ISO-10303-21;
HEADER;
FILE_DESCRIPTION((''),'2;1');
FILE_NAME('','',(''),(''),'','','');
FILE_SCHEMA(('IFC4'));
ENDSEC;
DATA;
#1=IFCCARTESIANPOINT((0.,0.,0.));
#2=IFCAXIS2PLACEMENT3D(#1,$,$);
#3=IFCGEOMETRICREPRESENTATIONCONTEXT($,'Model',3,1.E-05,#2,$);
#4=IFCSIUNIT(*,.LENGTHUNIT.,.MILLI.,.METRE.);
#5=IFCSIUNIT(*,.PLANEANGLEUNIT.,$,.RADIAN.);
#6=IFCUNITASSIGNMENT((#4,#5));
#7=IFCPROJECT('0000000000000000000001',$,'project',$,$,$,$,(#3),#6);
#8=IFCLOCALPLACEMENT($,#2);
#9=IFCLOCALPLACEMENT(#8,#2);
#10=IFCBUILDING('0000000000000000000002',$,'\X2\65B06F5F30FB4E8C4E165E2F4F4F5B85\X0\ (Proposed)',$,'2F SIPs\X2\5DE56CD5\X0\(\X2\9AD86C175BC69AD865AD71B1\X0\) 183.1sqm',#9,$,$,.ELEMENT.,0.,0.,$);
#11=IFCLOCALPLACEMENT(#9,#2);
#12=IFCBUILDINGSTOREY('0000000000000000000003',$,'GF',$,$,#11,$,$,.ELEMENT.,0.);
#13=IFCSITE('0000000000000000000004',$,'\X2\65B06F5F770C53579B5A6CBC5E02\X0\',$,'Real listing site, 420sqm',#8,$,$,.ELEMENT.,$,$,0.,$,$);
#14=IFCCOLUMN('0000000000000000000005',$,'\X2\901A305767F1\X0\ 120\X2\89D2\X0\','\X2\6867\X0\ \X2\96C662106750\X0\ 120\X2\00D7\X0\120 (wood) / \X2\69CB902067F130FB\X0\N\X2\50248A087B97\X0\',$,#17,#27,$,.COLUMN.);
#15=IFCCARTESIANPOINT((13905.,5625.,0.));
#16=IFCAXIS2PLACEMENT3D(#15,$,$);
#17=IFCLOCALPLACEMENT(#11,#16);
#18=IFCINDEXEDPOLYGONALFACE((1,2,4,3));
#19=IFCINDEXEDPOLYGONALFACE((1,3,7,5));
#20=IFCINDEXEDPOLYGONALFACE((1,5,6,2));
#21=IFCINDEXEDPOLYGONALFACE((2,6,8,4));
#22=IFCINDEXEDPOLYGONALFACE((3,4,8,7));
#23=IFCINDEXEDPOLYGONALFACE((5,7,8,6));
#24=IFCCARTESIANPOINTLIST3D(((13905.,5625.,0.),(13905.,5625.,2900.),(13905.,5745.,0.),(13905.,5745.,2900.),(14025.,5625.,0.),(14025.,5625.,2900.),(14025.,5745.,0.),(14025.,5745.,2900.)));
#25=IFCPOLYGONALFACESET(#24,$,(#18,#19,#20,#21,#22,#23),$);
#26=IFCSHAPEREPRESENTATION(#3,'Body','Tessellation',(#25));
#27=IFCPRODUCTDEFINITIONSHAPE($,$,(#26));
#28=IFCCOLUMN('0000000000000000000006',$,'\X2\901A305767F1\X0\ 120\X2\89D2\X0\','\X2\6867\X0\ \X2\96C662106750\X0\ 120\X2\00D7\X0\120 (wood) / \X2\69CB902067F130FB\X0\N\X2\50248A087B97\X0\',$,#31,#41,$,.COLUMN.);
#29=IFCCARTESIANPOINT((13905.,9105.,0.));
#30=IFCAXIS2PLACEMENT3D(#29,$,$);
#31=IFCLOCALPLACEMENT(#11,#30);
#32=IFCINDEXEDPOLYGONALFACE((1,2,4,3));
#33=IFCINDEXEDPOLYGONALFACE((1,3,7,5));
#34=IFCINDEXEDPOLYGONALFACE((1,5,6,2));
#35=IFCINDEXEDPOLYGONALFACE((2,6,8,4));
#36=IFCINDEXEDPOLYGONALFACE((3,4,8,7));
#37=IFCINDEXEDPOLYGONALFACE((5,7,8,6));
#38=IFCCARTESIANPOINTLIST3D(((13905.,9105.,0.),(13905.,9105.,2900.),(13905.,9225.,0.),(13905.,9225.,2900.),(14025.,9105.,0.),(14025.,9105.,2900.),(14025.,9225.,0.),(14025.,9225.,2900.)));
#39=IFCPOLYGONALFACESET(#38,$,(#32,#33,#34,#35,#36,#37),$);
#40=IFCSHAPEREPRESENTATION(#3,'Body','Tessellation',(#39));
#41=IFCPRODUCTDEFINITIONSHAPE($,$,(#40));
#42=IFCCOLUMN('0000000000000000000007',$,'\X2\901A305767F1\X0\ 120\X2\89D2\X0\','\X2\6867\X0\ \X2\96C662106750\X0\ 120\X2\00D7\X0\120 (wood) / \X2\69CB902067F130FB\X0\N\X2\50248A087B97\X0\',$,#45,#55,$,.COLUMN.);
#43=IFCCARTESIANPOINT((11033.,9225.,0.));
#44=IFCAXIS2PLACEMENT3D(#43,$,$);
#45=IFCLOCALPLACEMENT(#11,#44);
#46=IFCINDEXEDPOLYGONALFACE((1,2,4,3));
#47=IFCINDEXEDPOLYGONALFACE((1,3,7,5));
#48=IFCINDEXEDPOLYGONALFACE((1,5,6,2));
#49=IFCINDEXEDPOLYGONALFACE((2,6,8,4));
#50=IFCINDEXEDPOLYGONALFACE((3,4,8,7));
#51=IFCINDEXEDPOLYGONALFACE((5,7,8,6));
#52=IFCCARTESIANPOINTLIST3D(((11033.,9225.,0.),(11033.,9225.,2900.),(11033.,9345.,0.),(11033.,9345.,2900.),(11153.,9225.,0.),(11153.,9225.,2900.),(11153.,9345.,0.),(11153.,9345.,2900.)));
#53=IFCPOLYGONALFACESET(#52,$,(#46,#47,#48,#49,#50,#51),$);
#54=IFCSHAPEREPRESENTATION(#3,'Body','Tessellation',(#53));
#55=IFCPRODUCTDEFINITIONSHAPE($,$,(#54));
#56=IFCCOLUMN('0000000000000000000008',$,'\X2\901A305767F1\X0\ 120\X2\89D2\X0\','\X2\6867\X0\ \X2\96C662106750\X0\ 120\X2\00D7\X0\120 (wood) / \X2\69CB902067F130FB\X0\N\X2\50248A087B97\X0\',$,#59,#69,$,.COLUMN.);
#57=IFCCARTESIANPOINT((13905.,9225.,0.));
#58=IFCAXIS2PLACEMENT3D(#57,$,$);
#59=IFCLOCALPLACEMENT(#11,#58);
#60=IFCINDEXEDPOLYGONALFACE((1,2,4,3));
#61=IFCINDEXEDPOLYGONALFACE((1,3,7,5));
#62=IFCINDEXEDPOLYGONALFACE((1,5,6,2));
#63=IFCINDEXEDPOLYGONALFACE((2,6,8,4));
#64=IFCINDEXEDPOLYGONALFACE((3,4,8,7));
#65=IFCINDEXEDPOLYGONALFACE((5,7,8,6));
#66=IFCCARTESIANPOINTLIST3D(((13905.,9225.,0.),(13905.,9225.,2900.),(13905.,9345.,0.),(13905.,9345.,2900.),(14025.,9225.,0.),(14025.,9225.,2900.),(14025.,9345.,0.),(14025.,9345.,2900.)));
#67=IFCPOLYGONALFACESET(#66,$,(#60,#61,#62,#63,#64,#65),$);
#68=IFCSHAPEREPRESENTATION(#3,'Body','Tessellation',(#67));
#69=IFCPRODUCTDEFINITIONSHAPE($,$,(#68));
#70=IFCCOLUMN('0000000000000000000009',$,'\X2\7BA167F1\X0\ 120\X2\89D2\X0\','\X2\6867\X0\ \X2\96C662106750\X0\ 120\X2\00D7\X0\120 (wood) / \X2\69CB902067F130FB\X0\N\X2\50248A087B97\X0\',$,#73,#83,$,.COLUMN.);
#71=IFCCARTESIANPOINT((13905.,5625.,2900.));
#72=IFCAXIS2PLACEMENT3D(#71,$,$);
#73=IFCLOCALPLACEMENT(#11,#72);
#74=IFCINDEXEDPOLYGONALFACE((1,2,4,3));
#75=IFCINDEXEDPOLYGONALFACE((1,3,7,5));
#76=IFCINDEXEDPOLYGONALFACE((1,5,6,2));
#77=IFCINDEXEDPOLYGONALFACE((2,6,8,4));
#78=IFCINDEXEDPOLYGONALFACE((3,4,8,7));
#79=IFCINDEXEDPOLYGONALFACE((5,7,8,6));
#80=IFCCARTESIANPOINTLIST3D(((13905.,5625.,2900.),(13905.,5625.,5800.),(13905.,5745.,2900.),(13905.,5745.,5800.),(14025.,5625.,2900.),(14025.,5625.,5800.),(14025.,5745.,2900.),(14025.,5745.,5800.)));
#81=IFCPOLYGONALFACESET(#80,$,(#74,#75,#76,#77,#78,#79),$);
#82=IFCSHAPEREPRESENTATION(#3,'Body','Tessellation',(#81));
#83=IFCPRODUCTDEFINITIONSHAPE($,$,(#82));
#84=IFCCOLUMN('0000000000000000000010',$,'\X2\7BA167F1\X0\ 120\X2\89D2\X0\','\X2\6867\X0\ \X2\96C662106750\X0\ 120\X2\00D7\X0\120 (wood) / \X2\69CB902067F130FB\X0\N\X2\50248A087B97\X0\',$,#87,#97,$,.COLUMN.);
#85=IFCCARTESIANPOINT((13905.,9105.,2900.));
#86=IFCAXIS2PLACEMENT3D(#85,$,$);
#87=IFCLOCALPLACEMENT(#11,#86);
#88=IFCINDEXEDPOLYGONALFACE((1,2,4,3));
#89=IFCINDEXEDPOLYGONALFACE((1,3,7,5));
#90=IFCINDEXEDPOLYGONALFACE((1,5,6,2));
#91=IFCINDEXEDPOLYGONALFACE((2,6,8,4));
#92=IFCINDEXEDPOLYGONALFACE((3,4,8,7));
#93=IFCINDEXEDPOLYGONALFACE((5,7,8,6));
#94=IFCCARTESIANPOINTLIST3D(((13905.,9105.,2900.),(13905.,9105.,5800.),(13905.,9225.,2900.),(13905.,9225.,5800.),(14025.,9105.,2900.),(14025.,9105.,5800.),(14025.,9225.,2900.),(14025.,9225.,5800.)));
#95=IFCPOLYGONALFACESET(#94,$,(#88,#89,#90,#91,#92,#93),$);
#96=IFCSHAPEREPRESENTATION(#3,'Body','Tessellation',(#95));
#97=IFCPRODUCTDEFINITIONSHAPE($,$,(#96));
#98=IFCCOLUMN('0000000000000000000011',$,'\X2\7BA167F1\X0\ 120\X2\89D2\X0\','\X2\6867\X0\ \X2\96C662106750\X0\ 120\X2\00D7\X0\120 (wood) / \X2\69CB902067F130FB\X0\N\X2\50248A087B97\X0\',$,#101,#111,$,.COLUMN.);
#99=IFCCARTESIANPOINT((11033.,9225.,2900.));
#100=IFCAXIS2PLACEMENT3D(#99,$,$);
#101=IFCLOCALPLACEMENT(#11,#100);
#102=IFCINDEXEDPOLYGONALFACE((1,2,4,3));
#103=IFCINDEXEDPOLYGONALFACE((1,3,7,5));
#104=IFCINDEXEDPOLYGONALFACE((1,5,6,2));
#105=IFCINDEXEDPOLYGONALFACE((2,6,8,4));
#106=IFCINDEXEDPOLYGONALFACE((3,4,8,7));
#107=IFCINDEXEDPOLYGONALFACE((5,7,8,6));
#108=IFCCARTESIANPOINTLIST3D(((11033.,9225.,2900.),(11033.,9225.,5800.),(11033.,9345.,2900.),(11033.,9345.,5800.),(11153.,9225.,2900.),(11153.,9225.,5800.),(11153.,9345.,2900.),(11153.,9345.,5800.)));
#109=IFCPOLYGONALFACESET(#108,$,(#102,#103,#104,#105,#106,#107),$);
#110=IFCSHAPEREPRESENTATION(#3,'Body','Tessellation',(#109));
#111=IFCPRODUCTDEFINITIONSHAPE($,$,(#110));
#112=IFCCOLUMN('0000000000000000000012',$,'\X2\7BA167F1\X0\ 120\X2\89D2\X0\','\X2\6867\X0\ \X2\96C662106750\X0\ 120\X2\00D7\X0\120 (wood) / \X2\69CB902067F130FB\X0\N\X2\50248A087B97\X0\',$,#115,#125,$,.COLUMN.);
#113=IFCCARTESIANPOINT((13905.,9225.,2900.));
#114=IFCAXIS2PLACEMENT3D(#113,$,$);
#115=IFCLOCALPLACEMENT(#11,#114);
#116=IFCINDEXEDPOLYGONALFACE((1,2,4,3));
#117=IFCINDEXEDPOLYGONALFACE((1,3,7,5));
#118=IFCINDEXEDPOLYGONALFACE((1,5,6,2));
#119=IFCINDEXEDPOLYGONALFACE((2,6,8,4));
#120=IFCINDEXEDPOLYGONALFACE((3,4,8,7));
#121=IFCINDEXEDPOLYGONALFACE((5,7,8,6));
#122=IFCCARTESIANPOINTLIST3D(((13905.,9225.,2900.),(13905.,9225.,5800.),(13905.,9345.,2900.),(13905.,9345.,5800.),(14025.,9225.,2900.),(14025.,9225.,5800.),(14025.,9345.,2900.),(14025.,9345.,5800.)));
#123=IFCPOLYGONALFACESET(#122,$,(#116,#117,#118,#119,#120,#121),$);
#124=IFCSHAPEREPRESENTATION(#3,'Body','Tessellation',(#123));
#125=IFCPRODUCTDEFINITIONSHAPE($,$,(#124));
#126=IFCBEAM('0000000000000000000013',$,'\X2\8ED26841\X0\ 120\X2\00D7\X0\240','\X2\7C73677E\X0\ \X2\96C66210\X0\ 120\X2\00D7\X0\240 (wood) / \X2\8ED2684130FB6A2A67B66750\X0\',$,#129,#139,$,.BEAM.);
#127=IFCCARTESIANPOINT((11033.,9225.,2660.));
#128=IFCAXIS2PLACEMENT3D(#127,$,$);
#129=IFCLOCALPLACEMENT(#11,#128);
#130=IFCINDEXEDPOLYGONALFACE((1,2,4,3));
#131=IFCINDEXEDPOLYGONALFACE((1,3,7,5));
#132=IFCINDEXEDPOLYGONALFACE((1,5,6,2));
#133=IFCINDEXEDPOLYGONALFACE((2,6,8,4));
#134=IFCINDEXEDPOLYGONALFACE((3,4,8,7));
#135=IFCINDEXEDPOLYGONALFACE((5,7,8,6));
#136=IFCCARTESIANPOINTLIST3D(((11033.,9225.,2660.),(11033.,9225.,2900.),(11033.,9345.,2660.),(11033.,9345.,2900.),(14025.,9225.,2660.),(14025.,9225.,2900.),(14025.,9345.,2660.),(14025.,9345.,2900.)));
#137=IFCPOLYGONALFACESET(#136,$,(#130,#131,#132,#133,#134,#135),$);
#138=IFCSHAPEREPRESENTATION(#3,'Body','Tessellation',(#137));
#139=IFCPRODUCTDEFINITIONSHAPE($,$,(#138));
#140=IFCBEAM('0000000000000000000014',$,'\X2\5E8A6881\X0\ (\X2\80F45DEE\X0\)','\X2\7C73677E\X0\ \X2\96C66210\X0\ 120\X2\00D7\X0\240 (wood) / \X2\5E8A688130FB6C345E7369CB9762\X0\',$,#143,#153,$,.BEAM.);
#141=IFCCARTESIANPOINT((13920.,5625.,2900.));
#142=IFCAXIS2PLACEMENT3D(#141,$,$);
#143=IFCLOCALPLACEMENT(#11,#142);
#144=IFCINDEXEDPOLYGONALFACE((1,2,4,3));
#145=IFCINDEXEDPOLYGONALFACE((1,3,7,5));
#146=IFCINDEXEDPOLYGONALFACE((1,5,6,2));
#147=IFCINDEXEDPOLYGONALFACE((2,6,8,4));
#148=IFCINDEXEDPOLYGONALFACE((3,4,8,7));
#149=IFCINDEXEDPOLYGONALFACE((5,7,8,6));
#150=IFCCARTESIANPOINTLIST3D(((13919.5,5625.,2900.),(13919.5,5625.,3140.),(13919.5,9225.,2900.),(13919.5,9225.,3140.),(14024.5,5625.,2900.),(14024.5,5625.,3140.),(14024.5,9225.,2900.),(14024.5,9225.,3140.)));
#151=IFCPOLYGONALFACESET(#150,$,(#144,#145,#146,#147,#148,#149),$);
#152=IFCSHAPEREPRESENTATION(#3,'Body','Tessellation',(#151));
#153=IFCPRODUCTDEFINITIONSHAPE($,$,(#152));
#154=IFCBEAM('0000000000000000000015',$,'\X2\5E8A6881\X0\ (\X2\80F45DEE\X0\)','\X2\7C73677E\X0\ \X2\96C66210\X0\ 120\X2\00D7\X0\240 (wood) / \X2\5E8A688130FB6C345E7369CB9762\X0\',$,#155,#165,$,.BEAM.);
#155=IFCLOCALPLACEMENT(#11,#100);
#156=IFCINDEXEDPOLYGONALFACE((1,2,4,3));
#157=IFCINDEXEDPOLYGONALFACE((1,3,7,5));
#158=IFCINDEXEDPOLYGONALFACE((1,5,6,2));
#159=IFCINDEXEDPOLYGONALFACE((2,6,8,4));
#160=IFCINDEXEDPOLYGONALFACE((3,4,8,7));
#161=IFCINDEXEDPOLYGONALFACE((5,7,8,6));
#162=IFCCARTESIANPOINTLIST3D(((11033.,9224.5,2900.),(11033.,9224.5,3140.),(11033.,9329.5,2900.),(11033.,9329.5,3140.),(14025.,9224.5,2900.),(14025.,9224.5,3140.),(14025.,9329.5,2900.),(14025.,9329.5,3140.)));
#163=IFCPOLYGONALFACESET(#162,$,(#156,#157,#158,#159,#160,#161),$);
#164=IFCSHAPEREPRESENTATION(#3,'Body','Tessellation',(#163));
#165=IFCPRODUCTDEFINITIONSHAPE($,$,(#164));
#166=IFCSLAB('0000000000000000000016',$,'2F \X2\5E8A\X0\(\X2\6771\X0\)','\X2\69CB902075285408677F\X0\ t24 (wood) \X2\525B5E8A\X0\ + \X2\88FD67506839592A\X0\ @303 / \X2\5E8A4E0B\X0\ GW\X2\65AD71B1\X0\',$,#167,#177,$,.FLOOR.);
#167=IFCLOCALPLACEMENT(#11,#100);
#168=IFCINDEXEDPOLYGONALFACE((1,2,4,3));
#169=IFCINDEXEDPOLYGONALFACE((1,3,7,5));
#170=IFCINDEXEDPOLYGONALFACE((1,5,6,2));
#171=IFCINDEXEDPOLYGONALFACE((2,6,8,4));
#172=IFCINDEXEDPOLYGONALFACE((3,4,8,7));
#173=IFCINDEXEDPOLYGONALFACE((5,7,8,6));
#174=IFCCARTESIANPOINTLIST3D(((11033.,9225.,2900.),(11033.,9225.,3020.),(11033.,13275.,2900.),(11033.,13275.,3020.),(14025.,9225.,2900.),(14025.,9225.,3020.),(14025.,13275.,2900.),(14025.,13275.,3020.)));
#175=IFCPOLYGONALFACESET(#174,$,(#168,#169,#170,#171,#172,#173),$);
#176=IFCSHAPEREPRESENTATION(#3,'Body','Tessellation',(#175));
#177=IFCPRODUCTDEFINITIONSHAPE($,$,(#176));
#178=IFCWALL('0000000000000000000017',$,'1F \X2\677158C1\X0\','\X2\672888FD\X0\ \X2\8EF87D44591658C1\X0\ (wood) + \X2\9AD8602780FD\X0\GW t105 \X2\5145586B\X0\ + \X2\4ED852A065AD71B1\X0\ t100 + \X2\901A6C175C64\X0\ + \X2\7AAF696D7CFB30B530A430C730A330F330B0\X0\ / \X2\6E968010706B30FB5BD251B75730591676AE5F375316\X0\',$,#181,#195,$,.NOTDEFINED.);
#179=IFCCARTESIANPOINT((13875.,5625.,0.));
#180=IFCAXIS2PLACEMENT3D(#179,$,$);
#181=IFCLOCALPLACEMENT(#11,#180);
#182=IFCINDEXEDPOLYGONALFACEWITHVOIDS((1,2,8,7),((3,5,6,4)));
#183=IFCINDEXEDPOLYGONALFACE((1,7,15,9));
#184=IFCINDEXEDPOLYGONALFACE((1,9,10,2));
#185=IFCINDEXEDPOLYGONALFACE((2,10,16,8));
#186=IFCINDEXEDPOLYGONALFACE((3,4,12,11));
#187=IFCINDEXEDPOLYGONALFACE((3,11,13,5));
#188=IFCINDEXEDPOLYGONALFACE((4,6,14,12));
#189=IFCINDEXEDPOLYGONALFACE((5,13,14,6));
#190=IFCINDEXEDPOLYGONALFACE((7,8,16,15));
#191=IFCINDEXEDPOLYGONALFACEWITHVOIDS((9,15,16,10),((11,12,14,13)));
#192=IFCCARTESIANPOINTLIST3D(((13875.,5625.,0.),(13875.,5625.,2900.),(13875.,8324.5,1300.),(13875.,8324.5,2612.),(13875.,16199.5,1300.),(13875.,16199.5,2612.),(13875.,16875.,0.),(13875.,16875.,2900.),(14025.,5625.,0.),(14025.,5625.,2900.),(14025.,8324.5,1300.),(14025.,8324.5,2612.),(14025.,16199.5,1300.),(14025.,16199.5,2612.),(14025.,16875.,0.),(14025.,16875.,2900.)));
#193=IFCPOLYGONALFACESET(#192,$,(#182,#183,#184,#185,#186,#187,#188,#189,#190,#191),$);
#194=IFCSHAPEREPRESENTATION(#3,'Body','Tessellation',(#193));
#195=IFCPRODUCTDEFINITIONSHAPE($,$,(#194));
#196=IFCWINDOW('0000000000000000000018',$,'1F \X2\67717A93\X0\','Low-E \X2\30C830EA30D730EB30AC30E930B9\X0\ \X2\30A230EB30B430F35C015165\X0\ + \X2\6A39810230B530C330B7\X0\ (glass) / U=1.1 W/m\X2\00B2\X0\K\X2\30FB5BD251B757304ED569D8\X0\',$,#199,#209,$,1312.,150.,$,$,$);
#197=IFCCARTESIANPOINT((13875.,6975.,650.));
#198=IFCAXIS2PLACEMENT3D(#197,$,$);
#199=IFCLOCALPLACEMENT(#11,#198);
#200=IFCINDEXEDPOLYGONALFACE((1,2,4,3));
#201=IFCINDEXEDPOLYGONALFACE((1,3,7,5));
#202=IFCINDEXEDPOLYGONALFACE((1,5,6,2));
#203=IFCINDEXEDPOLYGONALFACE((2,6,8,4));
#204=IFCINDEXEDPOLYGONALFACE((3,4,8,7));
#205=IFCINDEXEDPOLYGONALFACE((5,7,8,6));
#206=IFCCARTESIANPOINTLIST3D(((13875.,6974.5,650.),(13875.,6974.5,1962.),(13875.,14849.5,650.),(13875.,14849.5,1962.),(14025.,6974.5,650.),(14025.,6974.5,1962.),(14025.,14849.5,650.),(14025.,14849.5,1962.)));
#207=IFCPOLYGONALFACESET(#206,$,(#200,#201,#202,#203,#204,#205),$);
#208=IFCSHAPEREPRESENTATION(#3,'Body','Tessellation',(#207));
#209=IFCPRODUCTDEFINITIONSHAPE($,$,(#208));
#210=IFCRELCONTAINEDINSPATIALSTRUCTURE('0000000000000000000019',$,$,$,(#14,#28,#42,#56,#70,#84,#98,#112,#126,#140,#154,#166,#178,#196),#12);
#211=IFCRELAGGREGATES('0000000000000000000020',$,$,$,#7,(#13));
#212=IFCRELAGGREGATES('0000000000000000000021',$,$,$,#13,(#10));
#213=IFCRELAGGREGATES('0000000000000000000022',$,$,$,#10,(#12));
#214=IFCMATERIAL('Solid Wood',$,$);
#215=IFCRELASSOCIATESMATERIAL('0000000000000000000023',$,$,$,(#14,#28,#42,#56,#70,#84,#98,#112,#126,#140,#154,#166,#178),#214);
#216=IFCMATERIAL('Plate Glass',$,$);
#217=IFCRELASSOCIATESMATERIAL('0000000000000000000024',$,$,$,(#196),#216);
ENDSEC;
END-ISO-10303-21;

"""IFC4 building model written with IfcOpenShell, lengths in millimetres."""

from ifc_helpers import new_model, si_unit, frame, frame_2d, origin, place, context, project, spatial, rectangle, extrude, material, element, fill, save


model = new_model("IFC4")

# Units and contexts
model_context = context("Model", 3, precision=1e-05, world=origin())
ifc_project = project(units=[si_unit("LENGTHUNIT", "METRE", prefix="MILLI"), si_unit("PLANEANGLEUNIT", "RADIAN")], contexts=[model_context])

# Site, building, storey
site_placement = place(None, origin())
site = spatial("IfcSite", under=ifc_project, at=site_placement, Name="新潟県南魚沼市", ObjectType="Real listing site, 420sqm", CompositionType="ELEMENT", RefElevation=0.0)
building_placement = place(site_placement, origin())
building = spatial("IfcBuilding", under=site, at=building_placement, Name="新潟・二世帯住宅 (Proposed)", ObjectType="2F SIPs工法(高気密高断熱) 183.1sqm", CompositionType="ELEMENT", ElevationOfRefHeight=0.0, ElevationOfTerrain=0.0)
storey_placement = place(building_placement, origin())
storey = spatial("IfcBuildingStorey", under=building, at=storey_placement, Name="GF", CompositionType="ELEMENT", Elevation=0.0)

# Columns
ifc_material_1 = material(Name="Solid Wood")
column_1_placement = place(storey_placement, frame((13905.0, 5625.0, 0.0)))
element("IfcColumn", 1, at=column_1_placement, inside=storey, material=ifc_material_1, Name="通し柱 120角", Description="桧 集成材 120×120 (wood) / 構造柱・N値計算", PredefinedType="COLUMN", context=model_context, shape_type="SweptSolid", body=[
    extrude(rectangle(XDim=120.0, YDim=120.0, at=frame_2d((60.0, 60.0))), frame((13905.0, 5625.0, 0.0)), (0.0, 0.0, 1.0), 2900.0),
])
column_2_placement = place(storey_placement, frame((13905.0, 9105.0, 0.0)))
element("IfcColumn", 2, at=column_2_placement, inside=storey, material=ifc_material_1, Name="通し柱 120角", Description="桧 集成材 120×120 (wood) / 構造柱・N値計算", PredefinedType="COLUMN", context=model_context, shape_type="SweptSolid", body=[
    extrude(rectangle(XDim=120.0, YDim=120.0, at=frame_2d((60.0, 60.0))), frame((13905.0, 9105.0, 0.0)), (0.0, 0.0, 1.0), 2900.0),
])
column_3_placement = place(storey_placement, frame((11033.0, 9225.0, 0.0)))
element("IfcColumn", 3, at=column_3_placement, inside=storey, material=ifc_material_1, Name="通し柱 120角", Description="桧 集成材 120×120 (wood) / 構造柱・N値計算", PredefinedType="COLUMN", context=model_context, shape_type="SweptSolid", body=[
    extrude(rectangle(XDim=120.0, YDim=120.0, at=frame_2d((60.0, 60.0))), frame((11033.0, 9225.0, 0.0)), (0.0, 0.0, 1.0), 2900.0),
])
column_4_placement = place(storey_placement, frame((13905.0, 9225.0, 0.0)))
element("IfcColumn", 4, at=column_4_placement, inside=storey, material=ifc_material_1, Name="通し柱 120角", Description="桧 集成材 120×120 (wood) / 構造柱・N値計算", PredefinedType="COLUMN", context=model_context, shape_type="SweptSolid", body=[
    extrude(rectangle(XDim=120.0, YDim=120.0, at=frame_2d((60.0, 60.0))), frame((13905.0, 9225.0, 0.0)), (0.0, 0.0, 1.0), 2900.0),
])
column_5_placement = place(storey_placement, frame((13905.0, 5625.0, 2900.0)))
element("IfcColumn", 5, at=column_5_placement, inside=storey, material=ifc_material_1, Name="管柱 120角", Description="桧 集成材 120×120 (wood) / 構造柱・N値計算", PredefinedType="COLUMN", context=model_context, shape_type="SweptSolid", body=[
    extrude(rectangle(XDim=120.0, YDim=120.0, at=frame_2d((60.0, 60.0))), frame((13905.0, 5625.0, 2900.0)), (0.0, 0.0, 1.0), 2900.0),
])
column_6_placement = place(storey_placement, frame((13905.0, 9105.0, 2900.0)))
element("IfcColumn", 6, at=column_6_placement, inside=storey, material=ifc_material_1, Name="管柱 120角", Description="桧 集成材 120×120 (wood) / 構造柱・N値計算", PredefinedType="COLUMN", context=model_context, shape_type="SweptSolid", body=[
    extrude(rectangle(XDim=120.0, YDim=120.0, at=frame_2d((60.0, 60.0))), frame((13905.0, 9105.0, 2900.0)), (0.0, 0.0, 1.0), 2900.0),
])
column_7_placement = place(storey_placement, frame((11033.0, 9225.0, 2900.0)))
element("IfcColumn", 7, at=column_7_placement, inside=storey, material=ifc_material_1, Name="管柱 120角", Description="桧 集成材 120×120 (wood) / 構造柱・N値計算", PredefinedType="COLUMN", context=model_context, shape_type="SweptSolid", body=[
    extrude(rectangle(XDim=120.0, YDim=120.0, at=frame_2d((60.0, 60.0))), frame((11033.0, 9225.0, 2900.0)), (0.0, 0.0, 1.0), 2900.0),
])
column_8_placement = place(storey_placement, frame((13905.0, 9225.0, 2900.0)))
element("IfcColumn", 8, at=column_8_placement, inside=storey, material=ifc_material_1, Name="管柱 120角", Description="桧 集成材 120×120 (wood) / 構造柱・N値計算", PredefinedType="COLUMN", context=model_context, shape_type="SweptSolid", body=[
    extrude(rectangle(XDim=120.0, YDim=120.0, at=frame_2d((60.0, 60.0))), frame((13905.0, 9225.0, 2900.0)), (0.0, 0.0, 1.0), 2900.0),
])

# Beams
beam_1_placement = place(storey_placement, frame((11033.0, 9225.0, 2660.0)))
element("IfcBeam", 9, at=beam_1_placement, inside=storey, material=ifc_material_1, Name="軒桁 120×240", Description="米松 集成 120×240 (wood) / 軒桁・横架材", PredefinedType="BEAM", context=model_context, shape_type="SweptSolid", body=[
    extrude(rectangle(XDim=2992.0, YDim=120.0, at=frame_2d((1496.0, 60.0))), frame((11033.0, 9225.0, 2660.0)), (0.0, 0.0, 1.0), 240.0),
])
beam_2_placement = place(storey_placement, frame((13920.0, 5625.0, 2900.0)))
element("IfcBeam", 10, at=beam_2_placement, inside=storey, material=ifc_material_1, Name="床梁 (胴差)", Description="米松 集成 120×240 (wood) / 床梁・水平構面", PredefinedType="BEAM", context=model_context, shape_type="SweptSolid", body=[
    extrude(rectangle(XDim=105.0, YDim=3600.0, at=frame_2d((52.0, 1800.0))), frame((13920.0, 5625.0, 2900.0)), (0.0, 0.0, 1.0), 240.0),
])
beam_3_placement = place(storey_placement, frame((11033.0, 9225.0, 2900.0)))
element("IfcBeam", 11, at=beam_3_placement, inside=storey, material=ifc_material_1, Name="床梁 (胴差)", Description="米松 集成 120×240 (wood) / 床梁・水平構面", PredefinedType="BEAM", context=model_context, shape_type="SweptSolid", body=[
    extrude(rectangle(XDim=2992.0, YDim=105.0, at=frame_2d((1496.0, 52.0))), frame((11033.0, 9225.0, 2900.0)), (0.0, 0.0, 1.0), 240.0),
])

# Slab
slab_placement = place(storey_placement, frame((11033.0, 9225.0, 2900.0)))
element("IfcSlab", 12, at=slab_placement, inside=storey, material=ifc_material_1, Name="2F 床(東)", Description="構造用合板 t24 (wood) 剛床 + 製材根太 @303 / 床下 GW断熱", PredefinedType="FLOOR", context=model_context, shape_type="SweptSolid", body=[
    extrude(rectangle(XDim=2992.0, YDim=4050.0, at=frame_2d((1496.0, 2025.0))), frame((11033.0, 9225.0, 2900.0)), (0.0, 0.0, 1.0), 120.0),
])

# Wall, opening, window
wall_1_placement = place(storey_placement, frame((13875.0, 5625.0, 0.0)))
wall_1 = element("IfcWall", 13, at=wall_1_placement, inside=storey, material=ifc_material_1, Name="1F 東壁", Description="木製 軸組外壁 (wood) + 高性能GW t105 充填 + 付加断熱 t100 + 通気層 + 窯業系サイディング / 準耐火・寒冷地外皮強化", PredefinedType="NOTDEFINED", context=model_context, shape_type="SweptSolid", body=[
    extrude(rectangle(XDim=150.0, YDim=11250.0, at=frame_2d((75.0, 5625.0))), frame((13875.0, 5625.0, 0.0)), (0.0, 0.0, 1.0), 2900.0),
])
opening_1_placement = place(storey_placement, frame((13875.0, 6975.0, 650.0)))
opening_1 = element("IfcOpeningElement", 14, at=opening_1_placement, cuts=wall_1, PredefinedType="NOTDEFINED", context=model_context, shape_type="SweptSolid", body=[
    extrude(rectangle(XDim=150.0, YDim=7875.0, at=frame_2d((75.0, 3937.0))), frame((13875.0, 6975.0, 650.0)), (0.0, 0.0, 1.0), 1312.0),
])
ifc_material_2 = material(Name="Plate Glass")
window_1_placement = place(storey_placement, frame((13875.0, 6975.0, 650.0)))
window_1 = element("IfcWindow", 15, at=window_1_placement, inside=storey, material=ifc_material_2, Name="1F 東窓", Description="Low-E トリプルガラス アルゴン封入 + 樹脂サッシ (glass) / U=1.1 W/m²K・寒冷地仕様", OverallHeight=1312.0, OverallWidth=150.0, context=model_context, shape_type="SweptSolid", body=[
    extrude(rectangle(XDim=150.0, YDim=7875.0, at=frame_2d((75.0, 3937.0))), frame((13875.0, 6975.0, 650.0)), (0.0, 0.0, 1.0), 1312.0),
])
fill(opening_1, window_1)

save(model, "model.ifc")
